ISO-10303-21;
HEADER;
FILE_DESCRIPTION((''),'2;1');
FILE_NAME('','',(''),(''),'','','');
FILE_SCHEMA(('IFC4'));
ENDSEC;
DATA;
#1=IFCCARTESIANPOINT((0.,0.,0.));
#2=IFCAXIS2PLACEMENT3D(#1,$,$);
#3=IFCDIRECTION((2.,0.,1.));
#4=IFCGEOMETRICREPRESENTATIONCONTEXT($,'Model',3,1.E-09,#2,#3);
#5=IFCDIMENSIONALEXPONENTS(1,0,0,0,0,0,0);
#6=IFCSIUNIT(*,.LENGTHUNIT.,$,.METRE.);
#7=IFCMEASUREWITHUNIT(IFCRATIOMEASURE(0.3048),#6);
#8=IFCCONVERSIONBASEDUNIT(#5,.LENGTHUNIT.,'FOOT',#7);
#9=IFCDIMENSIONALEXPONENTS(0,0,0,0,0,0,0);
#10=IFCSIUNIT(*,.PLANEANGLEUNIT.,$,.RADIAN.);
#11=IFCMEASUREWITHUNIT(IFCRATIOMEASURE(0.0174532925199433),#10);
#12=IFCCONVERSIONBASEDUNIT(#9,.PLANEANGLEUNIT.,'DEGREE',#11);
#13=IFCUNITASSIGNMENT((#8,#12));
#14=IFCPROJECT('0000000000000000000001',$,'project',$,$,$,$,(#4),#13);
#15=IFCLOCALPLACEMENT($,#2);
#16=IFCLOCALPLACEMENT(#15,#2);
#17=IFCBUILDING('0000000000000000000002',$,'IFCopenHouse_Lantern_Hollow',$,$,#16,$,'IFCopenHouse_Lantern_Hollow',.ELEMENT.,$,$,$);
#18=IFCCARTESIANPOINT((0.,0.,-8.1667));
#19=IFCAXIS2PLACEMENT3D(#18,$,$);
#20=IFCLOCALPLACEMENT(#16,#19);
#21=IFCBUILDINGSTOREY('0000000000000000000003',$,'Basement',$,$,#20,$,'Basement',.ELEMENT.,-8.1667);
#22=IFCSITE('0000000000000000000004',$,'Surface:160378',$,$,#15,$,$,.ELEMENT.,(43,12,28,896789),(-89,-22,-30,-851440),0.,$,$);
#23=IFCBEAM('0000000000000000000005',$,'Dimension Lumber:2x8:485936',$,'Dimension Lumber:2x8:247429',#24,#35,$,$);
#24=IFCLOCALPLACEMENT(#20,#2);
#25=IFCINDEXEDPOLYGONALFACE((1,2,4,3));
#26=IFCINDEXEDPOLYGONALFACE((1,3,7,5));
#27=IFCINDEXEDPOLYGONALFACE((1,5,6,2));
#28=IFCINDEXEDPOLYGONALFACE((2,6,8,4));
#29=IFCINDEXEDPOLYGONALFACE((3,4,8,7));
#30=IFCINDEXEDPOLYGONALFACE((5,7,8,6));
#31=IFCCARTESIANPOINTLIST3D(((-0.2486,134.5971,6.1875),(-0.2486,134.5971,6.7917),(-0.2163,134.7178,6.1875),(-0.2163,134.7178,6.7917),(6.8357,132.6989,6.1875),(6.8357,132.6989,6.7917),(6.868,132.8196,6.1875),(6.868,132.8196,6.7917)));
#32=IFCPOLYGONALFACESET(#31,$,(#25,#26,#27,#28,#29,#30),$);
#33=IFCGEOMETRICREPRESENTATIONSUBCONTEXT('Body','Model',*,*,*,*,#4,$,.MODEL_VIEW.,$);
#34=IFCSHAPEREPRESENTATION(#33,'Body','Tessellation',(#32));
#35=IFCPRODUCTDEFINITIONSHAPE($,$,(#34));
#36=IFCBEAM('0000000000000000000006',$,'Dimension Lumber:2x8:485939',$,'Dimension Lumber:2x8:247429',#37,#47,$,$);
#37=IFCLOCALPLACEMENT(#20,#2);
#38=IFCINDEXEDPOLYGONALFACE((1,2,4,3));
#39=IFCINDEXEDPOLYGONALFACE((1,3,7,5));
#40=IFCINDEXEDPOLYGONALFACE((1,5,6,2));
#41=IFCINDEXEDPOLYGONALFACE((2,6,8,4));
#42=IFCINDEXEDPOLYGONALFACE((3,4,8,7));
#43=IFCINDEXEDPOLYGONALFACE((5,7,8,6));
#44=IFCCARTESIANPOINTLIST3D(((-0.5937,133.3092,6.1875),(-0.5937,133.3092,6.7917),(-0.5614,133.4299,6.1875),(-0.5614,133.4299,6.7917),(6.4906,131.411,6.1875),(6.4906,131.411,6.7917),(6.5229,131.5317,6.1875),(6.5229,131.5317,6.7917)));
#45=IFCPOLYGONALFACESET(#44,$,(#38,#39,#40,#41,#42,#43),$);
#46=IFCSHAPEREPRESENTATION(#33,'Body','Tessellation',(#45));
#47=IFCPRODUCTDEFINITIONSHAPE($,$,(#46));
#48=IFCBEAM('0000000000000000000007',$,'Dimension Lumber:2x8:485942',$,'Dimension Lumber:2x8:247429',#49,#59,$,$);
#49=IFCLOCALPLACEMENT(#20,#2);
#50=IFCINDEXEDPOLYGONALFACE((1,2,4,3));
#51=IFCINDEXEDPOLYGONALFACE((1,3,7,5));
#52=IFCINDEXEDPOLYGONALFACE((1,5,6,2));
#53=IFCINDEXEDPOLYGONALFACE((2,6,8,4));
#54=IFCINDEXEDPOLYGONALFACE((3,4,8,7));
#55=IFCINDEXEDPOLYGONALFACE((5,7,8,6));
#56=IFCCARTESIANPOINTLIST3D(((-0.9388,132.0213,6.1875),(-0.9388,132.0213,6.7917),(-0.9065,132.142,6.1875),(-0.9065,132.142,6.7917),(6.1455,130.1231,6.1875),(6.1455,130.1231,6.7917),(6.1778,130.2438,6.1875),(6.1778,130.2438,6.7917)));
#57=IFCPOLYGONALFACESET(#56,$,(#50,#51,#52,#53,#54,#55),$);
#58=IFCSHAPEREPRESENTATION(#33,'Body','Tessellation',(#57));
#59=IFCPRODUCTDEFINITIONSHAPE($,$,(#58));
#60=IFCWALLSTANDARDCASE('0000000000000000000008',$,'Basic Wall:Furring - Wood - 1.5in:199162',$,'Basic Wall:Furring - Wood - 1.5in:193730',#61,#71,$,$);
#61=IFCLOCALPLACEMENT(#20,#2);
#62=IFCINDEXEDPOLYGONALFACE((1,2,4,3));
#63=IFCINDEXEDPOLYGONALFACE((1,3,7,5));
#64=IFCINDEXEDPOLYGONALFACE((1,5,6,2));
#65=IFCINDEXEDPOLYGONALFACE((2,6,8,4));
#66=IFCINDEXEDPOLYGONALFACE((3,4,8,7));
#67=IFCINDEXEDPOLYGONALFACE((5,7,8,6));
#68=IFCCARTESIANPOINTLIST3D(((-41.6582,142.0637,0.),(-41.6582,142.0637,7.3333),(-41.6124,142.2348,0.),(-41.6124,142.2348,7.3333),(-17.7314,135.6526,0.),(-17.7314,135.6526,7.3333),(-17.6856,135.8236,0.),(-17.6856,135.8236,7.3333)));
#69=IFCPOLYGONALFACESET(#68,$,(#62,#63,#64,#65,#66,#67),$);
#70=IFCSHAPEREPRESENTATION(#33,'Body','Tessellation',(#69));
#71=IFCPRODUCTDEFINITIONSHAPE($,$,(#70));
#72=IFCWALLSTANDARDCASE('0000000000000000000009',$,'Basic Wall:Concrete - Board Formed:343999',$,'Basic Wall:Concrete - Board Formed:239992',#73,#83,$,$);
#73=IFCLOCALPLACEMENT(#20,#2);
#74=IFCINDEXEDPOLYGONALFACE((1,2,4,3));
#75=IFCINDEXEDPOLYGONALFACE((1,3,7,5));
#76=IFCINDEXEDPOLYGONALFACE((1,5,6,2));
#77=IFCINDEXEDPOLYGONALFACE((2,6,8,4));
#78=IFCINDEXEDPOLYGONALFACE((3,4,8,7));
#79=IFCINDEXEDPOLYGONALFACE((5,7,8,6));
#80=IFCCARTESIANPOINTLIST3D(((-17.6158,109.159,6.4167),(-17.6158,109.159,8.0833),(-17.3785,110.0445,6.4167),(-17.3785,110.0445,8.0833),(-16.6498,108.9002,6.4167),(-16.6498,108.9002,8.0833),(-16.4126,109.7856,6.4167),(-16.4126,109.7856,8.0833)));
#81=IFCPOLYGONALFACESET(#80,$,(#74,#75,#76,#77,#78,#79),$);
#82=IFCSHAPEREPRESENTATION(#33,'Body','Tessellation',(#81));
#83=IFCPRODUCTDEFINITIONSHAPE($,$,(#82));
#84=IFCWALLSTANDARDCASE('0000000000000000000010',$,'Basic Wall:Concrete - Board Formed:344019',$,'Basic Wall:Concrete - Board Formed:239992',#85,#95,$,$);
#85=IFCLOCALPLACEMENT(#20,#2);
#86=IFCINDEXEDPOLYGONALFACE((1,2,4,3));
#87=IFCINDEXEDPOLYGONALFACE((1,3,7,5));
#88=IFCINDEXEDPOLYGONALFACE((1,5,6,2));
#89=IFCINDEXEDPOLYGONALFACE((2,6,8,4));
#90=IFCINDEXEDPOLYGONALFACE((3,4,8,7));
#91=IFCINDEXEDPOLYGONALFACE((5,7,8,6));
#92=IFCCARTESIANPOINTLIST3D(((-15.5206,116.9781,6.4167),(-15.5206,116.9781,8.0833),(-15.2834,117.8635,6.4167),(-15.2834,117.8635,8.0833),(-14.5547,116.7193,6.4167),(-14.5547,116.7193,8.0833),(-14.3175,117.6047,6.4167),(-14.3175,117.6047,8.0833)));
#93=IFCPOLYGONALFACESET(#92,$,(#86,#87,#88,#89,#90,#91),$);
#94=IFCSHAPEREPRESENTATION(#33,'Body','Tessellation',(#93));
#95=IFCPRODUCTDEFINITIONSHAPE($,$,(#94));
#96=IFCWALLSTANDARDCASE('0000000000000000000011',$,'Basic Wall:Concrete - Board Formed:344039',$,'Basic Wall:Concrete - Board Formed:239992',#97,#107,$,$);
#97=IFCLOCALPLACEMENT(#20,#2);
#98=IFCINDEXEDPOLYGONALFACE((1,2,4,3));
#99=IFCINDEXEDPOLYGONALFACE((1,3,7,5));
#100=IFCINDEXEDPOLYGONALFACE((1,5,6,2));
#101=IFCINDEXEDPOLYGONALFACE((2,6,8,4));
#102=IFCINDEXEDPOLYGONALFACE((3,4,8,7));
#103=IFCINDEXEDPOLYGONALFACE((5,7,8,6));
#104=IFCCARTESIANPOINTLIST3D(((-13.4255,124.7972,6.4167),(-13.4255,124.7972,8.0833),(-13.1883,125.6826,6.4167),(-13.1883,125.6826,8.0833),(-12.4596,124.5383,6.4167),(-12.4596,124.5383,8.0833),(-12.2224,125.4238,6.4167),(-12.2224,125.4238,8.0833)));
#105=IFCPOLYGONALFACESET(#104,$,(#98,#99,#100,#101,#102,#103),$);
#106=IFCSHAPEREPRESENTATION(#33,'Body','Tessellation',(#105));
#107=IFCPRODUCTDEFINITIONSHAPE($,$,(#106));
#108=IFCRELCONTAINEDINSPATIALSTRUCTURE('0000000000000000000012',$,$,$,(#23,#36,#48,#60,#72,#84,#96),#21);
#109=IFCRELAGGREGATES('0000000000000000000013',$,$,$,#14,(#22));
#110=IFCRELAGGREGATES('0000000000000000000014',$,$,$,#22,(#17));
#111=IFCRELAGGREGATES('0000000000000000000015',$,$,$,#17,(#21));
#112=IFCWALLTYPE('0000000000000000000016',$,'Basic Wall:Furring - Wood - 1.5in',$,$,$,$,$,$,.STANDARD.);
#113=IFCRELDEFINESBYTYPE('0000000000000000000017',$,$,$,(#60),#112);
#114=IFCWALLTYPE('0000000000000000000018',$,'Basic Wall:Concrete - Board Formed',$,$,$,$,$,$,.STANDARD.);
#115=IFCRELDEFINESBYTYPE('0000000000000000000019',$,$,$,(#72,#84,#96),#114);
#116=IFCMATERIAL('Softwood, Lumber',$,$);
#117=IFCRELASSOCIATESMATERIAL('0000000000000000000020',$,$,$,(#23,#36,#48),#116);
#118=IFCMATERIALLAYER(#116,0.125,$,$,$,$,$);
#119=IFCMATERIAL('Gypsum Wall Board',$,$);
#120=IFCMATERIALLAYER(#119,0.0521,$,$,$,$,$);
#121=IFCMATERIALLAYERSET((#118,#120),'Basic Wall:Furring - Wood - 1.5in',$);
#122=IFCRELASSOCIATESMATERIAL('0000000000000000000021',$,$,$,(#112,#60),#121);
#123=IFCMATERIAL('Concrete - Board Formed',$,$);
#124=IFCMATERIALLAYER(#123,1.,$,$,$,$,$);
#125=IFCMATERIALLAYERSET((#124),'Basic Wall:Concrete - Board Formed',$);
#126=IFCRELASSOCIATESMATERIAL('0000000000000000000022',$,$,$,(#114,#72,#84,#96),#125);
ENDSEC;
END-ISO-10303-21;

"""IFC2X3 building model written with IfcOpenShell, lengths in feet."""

from ifc_helpers import new_model, entity, si_unit, converted_unit, direction, frame, frame_2d, origin, place, context, subcontext, project, spatial, rectangle, extrude, material, layer, layer_set, layer_usage, type_object, element, save


model = new_model("IFC2X3")

# Units and contexts
model_context = context("Model", 3, precision=1e-09, world=origin(), true_north=direction((2.0, 0.0, 1.0)))
body_context = subcontext(model_context, "Body", "Model", "MODEL_VIEW")
ifc_project = project(units=[converted_unit("LENGTHUNIT", "FOOT", entity("IfcRatioMeasure", 0.3048), si_unit("LENGTHUNIT", "METRE"), dimensions=[1, 0, 0, 0, 0, 0, 0]), converted_unit("PLANEANGLEUNIT", "DEGREE", entity("IfcRatioMeasure", 0.0174532925199433), si_unit("PLANEANGLEUNIT", "RADIAN"), dimensions=[0, 0, 0, 0, 0, 0, 0])], contexts=[model_context])

# Site, building, storey
site_placement = place(None, origin())
site = spatial("IfcSite", under=ifc_project, at=site_placement, Name="Surface:160378", CompositionType="ELEMENT", RefLatitude=(43, 12, 28, 896789), RefLongitude=(-89, -22, -30, -851440), RefElevation=0.0)
building_placement = place(site_placement, origin())
building = spatial("IfcBuilding", under=site, at=building_placement, Name="IFCopenHouse_Lantern_Hollow", LongName="IFCopenHouse_Lantern_Hollow", CompositionType="ELEMENT")
storey_placement = place(building_placement, frame((0.0, 0.0, -8.1667)))
storey = spatial("IfcBuildingStorey", under=building, at=storey_placement, Name="Basement", LongName="Basement", CompositionType="ELEMENT", Elevation=-8.1667)

# Beams
ifc_material_1 = material(Name="Softwood, Lumber")
beam_1_placement = place(storey_placement, frame((-0.2324, 134.6575, 8.1667), z_axis=(0.0, 0.0, 1.0), x_axis=(0.965926, -0.258819, 0.0)))
element("IfcBeam", 1, at=beam_1_placement, inside=storey, material=ifc_material_1, Name="Dimension Lumber:2x8:485936", ObjectType="Dimension Lumber:2x8:247429", context=body_context, shape_type="SweptSolid", body=[
    extrude(rectangle(XDim=0.6042, YDim=0.125, at=frame_2d((0.0, 0.0), x_axis=(1.0, 0.0))), frame((0.0, 0.0, -1.6771), z_axis=(1.0, 0.0, 0.0), x_axis=(0.0, 0.0, -1.0)), (0.0, 0.0, 1.0), 7.3342),
])
beam_2_placement = place(storey_placement, frame((-0.5775, 133.3696, 8.1667), z_axis=(0.0, 0.0, 1.0), x_axis=(0.965926, -0.258819, 0.0)))
element("IfcBeam", 2, at=beam_2_placement, inside=storey, material=ifc_material_1, Name="Dimension Lumber:2x8:485939", ObjectType="Dimension Lumber:2x8:247429", context=body_context, shape_type="SweptSolid", body=[
    extrude(rectangle(XDim=0.6042, YDim=0.125, at=frame_2d((0.0, 0.0), x_axis=(1.0, 0.0))), frame((0.0, 0.0, -1.6771), z_axis=(1.0, 0.0, 0.0), x_axis=(0.0, 0.0, -1.0)), (0.0, 0.0, 1.0), 7.3342),
])
beam_3_placement = place(storey_placement, frame((-0.9226, 132.0817, 8.1667), z_axis=(0.0, 0.0, 1.0), x_axis=(0.965926, -0.258819, 0.0)))
element("IfcBeam", 3, at=beam_3_placement, inside=storey, material=ifc_material_1, Name="Dimension Lumber:2x8:485942", ObjectType="Dimension Lumber:2x8:247429", context=body_context, shape_type="SweptSolid", body=[
    extrude(rectangle(XDim=0.6042, YDim=0.125, at=frame_2d((0.0, 0.0), x_axis=(1.0, 0.0))), frame((0.0, 0.0, -1.6771), z_axis=(1.0, 0.0, 0.0), x_axis=(0.0, 0.0, -1.0)), (0.0, 0.0, 1.0), 7.3342),
])

# Walls
ifc_layer_1 = layer(ifc_material_1, 0.125)
ifc_material_2 = material(Name="Gypsum Wall Board")
ifc_layer_2 = layer(ifc_material_2, 0.0521)
ifc_layer_set_1 = layer_set([ifc_layer_1, ifc_layer_2], Name="Basic Wall:Furring - Wood - 1.5in")
ifc_layer_usage_1 = layer_usage(ifc_layer_set_1, "AXIS2", "NEGATIVE", 0.0885)
wall_type_1 = type_object("IfcWallType", Name="Basic Wall:Furring - Wood - 1.5in", PredefinedType="STANDARD", material=ifc_layer_set_1)
wall_1_placement = place(storey_placement, frame((-17.7085, 135.7381, 0.0), z_axis=(0.0, 0.0, 1.0), x_axis=(-0.965926, 0.258819, 0.0)))
element("IfcWallStandardCase", 4, at=wall_1_placement, inside=storey, type_object=wall_type_1, material=ifc_layer_usage_1, Name="Basic Wall:Furring - Wood - 1.5in:199162", ObjectType="Basic Wall:Furring - Wood - 1.5in:193730", context=body_context, shape_type="SweptSolid", body=[
    extrude(rectangle(XDim=24.7708, YDim=0.1771, at=frame_2d((12.3854, 0.0), x_axis=(-1.0, 0.0))), origin(), (0.0, 0.0, 1.0), 7.3333),
])
ifc_material_3 = material(Name="Concrete - Board Formed")
ifc_layer_3 = layer(ifc_material_3, 1.0)
ifc_layer_set_2 = layer_set([ifc_layer_3], Name="Basic Wall:Concrete - Board Formed")
ifc_layer_usage_2 = layer_usage(ifc_layer_set_2, "AXIS2", "NEGATIVE", 0.5)
wall_type_2 = type_object("IfcWallType", Name="Basic Wall:Concrete - Board Formed", PredefinedType="STANDARD", material=ifc_layer_set_2)
wall_2_placement = place(storey_placement, frame((-16.8955, 109.915, 6.4167), z_axis=(0.0, 0.0, 1.0), x_axis=(-0.258819, -0.965926, 0.0)))
element("IfcWallStandardCase", 5, at=wall_2_placement, inside=storey, type_object=wall_type_2, material=ifc_layer_usage_2, Name="Basic Wall:Concrete - Board Formed:343999", ObjectType="Basic Wall:Concrete - Board Formed:239992", context=body_context, shape_type="SweptSolid", body=[
    extrude(rectangle(XDim=0.9167, YDim=1.0, at=frame_2d((0.4583, 0.0), x_axis=(-1.0, 0.0))), origin(), (0.0, 0.0, 1.0), 1.6667),
])
ifc_layer_usage_3 = layer_usage(ifc_layer_set_2, "AXIS2", "NEGATIVE", 0.5)
wall_3_placement = place(storey_placement, frame((-14.8004, 117.7341, 6.4167), z_axis=(0.0, 0.0, 1.0), x_axis=(-0.258819, -0.965926, 0.0)))
element("IfcWallStandardCase", 6, at=wall_3_placement, inside=storey, type_object=wall_type_2, material=ifc_layer_usage_3, Name="Basic Wall:Concrete - Board Formed:344019", ObjectType="Basic Wall:Concrete - Board Formed:239992", context=body_context, shape_type="SweptSolid", body=[
    extrude(rectangle(XDim=0.9167, YDim=1.0, at=frame_2d((0.4583, 0.0), x_axis=(-1.0, 0.0))), origin(), (0.0, 0.0, 1.0), 1.6667),
])
ifc_layer_usage_4 = layer_usage(ifc_layer_set_2, "AXIS2", "NEGATIVE", 0.5)
wall_4_placement = place(storey_placement, frame((-12.7053, 125.5532, 6.4167), z_axis=(0.0, 0.0, 1.0), x_axis=(-0.258819, -0.965926, 0.0)))
element("IfcWallStandardCase", 7, at=wall_4_placement, inside=storey, type_object=wall_type_2, material=ifc_layer_usage_4, Name="Basic Wall:Concrete - Board Formed:344039", ObjectType="Basic Wall:Concrete - Board Formed:239992", context=body_context, shape_type="SweptSolid", body=[
    extrude(rectangle(XDim=0.9167, YDim=1.0, at=frame_2d((0.4583, 0.0), x_axis=(-1.0, 0.0))), origin(), (0.0, 0.0, 1.0), 1.6667),
])

save(model, "model.ifc")
